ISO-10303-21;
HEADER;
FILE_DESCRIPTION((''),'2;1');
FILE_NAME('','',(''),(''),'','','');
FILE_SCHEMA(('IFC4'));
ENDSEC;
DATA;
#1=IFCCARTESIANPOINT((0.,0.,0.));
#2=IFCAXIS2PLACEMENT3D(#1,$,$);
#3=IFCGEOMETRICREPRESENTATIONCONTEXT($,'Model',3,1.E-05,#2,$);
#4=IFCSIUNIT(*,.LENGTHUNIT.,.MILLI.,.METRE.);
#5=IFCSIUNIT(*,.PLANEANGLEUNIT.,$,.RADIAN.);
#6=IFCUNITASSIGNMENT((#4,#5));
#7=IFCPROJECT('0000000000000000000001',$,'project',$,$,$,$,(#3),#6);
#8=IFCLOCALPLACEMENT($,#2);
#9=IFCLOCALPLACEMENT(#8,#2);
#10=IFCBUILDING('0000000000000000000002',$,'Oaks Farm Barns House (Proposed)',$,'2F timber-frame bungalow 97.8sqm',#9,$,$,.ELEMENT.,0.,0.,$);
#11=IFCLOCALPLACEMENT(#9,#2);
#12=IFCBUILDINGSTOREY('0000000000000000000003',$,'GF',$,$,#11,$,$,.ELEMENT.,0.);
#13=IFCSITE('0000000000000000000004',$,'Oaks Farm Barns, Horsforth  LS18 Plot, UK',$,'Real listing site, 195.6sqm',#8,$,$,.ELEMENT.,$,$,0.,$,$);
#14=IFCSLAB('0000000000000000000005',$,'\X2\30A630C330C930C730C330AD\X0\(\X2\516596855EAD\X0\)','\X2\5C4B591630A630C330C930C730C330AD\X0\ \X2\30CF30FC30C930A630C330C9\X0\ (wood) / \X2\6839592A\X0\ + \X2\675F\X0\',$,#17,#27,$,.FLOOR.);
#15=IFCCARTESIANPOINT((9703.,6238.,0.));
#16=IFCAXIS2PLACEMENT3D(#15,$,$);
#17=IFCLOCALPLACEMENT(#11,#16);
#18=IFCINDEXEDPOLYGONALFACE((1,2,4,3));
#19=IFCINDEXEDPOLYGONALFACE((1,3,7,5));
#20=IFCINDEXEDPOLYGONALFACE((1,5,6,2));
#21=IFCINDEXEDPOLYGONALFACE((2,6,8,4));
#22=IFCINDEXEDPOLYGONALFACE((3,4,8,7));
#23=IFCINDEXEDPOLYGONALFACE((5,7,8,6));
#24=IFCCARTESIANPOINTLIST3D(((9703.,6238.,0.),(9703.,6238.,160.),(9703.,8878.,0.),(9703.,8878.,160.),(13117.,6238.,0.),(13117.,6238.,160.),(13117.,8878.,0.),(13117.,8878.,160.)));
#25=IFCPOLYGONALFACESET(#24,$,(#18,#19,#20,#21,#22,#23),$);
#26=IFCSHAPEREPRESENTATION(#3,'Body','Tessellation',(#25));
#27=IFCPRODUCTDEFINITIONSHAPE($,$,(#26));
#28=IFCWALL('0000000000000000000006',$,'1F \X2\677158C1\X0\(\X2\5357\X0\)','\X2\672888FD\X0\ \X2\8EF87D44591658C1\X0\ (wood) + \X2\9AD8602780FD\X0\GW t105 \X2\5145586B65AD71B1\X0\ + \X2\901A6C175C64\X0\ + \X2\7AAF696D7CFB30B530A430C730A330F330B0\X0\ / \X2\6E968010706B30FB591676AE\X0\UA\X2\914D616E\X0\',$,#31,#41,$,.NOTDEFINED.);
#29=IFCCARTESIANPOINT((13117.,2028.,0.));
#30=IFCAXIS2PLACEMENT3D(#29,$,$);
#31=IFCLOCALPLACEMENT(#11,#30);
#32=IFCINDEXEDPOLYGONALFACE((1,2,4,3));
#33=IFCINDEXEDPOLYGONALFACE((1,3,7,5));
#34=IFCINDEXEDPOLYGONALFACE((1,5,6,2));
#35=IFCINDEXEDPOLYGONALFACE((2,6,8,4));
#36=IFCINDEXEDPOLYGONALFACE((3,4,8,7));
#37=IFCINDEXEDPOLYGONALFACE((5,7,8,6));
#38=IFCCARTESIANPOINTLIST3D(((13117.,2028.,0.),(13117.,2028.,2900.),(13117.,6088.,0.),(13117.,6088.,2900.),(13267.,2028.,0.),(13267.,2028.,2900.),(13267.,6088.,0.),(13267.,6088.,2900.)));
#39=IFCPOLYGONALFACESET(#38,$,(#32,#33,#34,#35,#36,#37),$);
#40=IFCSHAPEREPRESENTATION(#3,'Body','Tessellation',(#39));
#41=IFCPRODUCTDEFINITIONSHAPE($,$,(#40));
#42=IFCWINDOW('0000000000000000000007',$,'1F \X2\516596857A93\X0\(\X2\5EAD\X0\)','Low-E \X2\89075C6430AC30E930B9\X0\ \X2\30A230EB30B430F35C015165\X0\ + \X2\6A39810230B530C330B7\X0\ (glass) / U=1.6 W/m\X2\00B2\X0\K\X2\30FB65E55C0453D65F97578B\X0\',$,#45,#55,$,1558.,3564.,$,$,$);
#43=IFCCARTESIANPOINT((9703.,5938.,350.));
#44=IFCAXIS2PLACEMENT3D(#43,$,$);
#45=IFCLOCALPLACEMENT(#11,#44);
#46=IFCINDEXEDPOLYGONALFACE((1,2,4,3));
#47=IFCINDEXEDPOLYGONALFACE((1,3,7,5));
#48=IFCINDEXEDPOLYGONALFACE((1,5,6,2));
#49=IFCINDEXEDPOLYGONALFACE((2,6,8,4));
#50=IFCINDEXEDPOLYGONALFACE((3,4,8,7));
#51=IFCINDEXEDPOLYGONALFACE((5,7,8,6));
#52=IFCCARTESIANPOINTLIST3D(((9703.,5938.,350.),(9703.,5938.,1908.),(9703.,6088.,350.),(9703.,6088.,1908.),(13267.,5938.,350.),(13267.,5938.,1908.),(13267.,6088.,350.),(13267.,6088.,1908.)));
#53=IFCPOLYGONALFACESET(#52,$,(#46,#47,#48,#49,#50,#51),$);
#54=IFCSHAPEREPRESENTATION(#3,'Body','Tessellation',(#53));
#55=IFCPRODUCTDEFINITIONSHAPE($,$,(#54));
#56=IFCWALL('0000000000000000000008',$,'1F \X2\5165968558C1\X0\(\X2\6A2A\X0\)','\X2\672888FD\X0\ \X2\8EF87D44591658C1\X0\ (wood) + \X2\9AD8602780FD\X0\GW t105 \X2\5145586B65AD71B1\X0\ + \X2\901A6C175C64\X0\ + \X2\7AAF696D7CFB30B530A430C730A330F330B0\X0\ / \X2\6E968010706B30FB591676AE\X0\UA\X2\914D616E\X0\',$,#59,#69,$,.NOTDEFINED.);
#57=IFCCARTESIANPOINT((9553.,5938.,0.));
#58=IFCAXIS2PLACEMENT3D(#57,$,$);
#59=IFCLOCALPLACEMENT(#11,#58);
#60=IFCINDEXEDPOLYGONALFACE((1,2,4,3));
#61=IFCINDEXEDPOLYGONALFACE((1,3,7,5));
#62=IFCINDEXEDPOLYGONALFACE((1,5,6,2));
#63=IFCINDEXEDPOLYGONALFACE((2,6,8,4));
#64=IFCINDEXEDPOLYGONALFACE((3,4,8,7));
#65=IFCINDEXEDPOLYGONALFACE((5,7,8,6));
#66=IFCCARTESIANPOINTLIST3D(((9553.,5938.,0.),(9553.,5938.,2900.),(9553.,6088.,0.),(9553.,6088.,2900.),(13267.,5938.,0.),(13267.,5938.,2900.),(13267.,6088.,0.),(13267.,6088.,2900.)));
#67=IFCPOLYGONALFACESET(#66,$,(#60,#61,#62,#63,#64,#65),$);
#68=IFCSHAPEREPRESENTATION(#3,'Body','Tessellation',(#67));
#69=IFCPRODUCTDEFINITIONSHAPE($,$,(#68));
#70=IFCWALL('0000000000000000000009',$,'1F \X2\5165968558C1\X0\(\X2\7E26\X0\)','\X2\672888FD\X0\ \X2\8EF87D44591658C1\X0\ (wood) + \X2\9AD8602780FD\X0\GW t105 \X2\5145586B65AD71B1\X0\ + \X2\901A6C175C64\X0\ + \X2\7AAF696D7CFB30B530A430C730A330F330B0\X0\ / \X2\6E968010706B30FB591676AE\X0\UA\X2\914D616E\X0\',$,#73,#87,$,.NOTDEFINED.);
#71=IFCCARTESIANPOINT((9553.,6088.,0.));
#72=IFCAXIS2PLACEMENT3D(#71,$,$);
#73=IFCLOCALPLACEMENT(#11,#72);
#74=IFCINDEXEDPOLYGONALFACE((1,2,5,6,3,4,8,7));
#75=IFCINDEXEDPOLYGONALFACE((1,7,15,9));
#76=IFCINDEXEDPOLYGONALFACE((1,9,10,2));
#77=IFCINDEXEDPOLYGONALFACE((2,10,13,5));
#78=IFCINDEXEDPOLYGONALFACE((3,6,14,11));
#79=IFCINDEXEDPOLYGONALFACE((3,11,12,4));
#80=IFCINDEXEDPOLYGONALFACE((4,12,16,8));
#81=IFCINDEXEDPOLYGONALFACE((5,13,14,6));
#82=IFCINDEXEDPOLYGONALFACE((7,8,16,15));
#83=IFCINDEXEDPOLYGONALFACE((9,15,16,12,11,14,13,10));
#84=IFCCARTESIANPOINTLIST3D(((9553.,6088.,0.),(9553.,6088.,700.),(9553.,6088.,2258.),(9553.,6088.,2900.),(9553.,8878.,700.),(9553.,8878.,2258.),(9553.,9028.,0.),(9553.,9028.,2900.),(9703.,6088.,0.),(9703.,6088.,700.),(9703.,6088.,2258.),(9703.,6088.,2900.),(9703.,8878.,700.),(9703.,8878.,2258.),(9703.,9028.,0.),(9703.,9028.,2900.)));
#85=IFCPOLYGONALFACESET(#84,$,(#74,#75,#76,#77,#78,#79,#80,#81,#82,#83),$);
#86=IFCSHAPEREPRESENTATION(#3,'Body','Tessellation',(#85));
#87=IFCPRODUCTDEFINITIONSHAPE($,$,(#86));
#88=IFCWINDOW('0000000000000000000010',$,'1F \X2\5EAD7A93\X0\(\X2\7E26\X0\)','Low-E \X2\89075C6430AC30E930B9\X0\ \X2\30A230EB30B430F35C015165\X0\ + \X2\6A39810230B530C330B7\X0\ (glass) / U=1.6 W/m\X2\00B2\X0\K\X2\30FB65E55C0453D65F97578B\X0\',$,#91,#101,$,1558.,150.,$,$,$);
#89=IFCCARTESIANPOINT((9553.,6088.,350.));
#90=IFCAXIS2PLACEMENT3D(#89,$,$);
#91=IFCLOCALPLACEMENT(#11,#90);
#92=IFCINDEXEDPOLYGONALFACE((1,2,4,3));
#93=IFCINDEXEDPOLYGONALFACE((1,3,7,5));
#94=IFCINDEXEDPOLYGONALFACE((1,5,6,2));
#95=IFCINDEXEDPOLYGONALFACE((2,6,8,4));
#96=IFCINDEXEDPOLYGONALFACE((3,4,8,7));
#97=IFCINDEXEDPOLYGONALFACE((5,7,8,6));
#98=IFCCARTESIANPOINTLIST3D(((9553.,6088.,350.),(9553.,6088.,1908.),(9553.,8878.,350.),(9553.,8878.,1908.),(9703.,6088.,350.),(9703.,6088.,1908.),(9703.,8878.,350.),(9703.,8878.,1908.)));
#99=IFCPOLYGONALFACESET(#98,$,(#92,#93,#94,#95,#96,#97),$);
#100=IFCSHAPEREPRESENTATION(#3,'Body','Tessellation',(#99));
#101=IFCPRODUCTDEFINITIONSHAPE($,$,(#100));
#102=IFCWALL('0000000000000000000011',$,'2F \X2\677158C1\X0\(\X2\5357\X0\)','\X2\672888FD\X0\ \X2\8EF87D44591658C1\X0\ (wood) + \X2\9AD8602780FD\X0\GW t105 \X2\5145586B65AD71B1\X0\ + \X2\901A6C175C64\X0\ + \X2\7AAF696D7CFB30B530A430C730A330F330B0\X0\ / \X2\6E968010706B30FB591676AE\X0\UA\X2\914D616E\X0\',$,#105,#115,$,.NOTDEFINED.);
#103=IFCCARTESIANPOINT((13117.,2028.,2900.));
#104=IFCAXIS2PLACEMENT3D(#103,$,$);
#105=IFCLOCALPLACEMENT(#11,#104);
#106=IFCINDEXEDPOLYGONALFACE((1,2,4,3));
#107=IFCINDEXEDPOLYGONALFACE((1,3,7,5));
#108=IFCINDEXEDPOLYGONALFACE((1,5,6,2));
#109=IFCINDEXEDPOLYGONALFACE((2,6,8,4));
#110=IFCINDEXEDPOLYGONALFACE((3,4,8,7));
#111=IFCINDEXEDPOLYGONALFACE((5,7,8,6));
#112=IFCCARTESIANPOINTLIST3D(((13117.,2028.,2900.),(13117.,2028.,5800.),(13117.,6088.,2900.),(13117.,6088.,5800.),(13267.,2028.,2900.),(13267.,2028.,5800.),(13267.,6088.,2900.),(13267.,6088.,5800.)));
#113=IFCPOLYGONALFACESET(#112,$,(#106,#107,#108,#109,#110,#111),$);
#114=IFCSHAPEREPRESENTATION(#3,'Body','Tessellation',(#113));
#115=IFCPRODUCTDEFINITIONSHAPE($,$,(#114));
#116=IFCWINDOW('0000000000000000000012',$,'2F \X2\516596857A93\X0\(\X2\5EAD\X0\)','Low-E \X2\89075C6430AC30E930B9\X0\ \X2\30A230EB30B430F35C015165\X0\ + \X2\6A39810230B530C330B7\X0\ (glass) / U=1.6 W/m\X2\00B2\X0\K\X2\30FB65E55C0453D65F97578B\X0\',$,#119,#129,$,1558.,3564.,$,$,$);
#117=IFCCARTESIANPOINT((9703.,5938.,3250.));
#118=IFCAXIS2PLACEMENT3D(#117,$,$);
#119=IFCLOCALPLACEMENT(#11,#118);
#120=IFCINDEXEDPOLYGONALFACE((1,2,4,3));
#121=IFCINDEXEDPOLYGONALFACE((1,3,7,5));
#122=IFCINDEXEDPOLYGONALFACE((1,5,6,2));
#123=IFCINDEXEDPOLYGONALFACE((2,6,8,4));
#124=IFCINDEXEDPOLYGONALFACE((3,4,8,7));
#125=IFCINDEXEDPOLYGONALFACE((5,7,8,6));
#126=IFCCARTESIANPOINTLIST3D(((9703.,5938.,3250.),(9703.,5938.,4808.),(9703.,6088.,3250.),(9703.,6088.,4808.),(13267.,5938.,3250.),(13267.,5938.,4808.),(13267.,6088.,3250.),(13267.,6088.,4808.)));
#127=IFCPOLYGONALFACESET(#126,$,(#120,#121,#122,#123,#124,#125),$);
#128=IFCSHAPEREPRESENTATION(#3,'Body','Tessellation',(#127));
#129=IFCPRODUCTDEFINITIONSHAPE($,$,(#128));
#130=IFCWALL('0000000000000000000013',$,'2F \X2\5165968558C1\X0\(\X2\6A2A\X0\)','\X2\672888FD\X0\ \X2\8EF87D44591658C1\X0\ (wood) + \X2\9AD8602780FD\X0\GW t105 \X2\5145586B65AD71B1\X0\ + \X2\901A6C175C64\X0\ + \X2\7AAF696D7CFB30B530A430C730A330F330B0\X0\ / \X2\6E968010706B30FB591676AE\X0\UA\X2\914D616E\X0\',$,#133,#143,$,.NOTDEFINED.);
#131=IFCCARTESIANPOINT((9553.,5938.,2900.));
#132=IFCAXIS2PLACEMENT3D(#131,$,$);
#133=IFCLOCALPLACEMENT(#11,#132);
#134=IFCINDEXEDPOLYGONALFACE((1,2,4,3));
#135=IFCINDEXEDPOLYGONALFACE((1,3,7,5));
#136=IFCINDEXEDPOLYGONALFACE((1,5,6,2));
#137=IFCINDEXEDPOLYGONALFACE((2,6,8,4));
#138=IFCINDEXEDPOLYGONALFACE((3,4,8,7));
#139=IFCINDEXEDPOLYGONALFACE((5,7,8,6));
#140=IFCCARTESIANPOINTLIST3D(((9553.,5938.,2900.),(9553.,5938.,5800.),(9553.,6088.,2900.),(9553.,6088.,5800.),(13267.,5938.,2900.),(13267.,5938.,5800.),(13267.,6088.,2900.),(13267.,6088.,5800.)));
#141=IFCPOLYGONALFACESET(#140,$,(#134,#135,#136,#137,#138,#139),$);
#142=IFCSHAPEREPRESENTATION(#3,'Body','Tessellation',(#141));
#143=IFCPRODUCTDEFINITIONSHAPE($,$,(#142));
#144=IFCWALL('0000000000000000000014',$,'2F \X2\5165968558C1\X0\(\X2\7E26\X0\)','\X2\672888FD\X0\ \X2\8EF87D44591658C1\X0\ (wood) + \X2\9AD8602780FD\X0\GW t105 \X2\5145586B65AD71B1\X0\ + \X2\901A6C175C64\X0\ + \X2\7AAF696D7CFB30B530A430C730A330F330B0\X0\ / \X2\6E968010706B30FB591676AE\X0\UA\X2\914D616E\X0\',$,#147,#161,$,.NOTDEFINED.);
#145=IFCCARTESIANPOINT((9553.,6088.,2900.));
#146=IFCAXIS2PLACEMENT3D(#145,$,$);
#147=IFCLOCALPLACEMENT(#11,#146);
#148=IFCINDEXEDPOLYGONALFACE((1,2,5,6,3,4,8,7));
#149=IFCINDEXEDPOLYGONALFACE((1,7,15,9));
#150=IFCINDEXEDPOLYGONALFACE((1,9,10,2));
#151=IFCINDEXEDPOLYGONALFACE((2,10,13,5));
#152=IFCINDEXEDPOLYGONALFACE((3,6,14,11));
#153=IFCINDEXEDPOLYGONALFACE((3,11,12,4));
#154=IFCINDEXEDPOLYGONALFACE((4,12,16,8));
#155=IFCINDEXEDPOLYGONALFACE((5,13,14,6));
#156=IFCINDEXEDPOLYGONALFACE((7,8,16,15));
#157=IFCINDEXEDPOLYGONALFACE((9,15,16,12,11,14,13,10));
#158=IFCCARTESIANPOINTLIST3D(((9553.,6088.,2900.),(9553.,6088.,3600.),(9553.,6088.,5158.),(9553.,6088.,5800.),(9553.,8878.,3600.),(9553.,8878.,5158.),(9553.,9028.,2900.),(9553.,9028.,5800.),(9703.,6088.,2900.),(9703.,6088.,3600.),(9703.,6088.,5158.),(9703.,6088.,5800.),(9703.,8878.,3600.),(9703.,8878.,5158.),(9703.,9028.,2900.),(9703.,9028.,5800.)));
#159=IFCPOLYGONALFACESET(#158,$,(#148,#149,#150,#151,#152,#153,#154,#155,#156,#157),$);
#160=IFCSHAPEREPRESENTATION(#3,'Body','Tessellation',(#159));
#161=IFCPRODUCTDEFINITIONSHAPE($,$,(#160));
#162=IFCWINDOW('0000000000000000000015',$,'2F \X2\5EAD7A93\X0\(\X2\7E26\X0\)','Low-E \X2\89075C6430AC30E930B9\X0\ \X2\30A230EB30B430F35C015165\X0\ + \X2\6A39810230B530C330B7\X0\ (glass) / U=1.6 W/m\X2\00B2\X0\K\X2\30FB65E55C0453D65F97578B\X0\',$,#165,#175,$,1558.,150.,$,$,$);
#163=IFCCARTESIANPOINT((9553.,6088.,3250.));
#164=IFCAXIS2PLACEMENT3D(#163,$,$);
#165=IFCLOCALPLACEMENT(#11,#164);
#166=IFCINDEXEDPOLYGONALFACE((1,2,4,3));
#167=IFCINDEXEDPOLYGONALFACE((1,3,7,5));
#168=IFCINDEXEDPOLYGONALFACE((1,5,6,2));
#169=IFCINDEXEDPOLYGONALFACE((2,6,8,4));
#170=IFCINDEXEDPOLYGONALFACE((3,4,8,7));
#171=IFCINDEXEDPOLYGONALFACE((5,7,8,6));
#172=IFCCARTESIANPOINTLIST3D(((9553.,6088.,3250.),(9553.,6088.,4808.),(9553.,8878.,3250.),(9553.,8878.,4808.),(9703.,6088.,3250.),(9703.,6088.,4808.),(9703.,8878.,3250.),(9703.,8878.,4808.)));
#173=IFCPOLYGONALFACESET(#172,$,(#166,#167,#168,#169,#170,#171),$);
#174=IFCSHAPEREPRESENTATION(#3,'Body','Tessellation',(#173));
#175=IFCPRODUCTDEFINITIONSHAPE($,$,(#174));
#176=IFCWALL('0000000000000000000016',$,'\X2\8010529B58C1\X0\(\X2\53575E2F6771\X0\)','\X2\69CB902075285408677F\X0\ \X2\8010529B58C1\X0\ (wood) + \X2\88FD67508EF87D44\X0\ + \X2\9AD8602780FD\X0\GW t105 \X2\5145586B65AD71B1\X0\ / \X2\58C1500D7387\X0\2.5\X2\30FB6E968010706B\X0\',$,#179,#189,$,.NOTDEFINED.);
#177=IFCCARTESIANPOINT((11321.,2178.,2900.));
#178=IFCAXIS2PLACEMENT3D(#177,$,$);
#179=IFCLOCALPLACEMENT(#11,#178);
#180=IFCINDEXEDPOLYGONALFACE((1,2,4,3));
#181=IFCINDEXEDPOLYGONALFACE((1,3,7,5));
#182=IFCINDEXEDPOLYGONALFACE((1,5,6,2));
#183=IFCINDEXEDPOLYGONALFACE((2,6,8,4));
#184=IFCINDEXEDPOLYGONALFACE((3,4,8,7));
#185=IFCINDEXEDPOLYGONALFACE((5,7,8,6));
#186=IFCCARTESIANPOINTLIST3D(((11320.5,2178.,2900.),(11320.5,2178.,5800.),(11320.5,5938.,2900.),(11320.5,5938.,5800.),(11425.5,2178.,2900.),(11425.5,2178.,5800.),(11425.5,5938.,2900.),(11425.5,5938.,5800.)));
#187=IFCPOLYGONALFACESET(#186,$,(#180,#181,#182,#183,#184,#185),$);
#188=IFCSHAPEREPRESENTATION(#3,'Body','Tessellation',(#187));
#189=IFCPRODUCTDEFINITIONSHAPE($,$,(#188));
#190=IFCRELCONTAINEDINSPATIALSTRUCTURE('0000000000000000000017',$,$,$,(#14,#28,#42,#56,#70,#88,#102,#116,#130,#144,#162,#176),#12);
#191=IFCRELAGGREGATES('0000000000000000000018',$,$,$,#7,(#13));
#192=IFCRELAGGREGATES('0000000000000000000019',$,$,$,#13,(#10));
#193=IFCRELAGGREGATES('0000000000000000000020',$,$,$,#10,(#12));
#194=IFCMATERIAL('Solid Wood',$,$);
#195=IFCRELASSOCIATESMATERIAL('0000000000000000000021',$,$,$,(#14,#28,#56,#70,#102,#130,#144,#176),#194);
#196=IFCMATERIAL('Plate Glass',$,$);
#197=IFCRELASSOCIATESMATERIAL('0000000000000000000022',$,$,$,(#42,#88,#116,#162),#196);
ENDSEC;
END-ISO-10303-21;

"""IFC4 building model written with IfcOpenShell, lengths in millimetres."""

from ifc_helpers import new_model, si_unit, frame, frame_2d, origin, place, context, project, spatial, rectangle, extrude, material, element, fill, save


model = new_model("IFC4")

# Units and contexts
model_context = context("Model", 3, precision=1e-05, world=origin())
ifc_project = project(units=[si_unit("LENGTHUNIT", "METRE", prefix="MILLI"), si_unit("PLANEANGLEUNIT", "RADIAN")], contexts=[model_context])

# Site, building, storey
site_placement = place(None, origin())
site = spatial("IfcSite", under=ifc_project, at=site_placement, Name="Oaks Farm Barns, Horsforth  LS18 Plot, UK", ObjectType="Real listing site, 195.6sqm", CompositionType="ELEMENT", RefElevation=0.0)
building_placement = place(site_placement, origin())
building = spatial("IfcBuilding", under=site, at=building_placement, Name="Oaks Farm Barns House (Proposed)", ObjectType="2F timber-frame bungalow 97.8sqm", CompositionType="ELEMENT", ElevationOfRefHeight=0.0, ElevationOfTerrain=0.0)
storey_placement = place(building_placement, origin())
storey = spatial("IfcBuildingStorey", under=building, at=storey_placement, Name="GF", CompositionType="ELEMENT", Elevation=0.0)

# Slab
ifc_material_1 = material(Name="Solid Wood")
slab_placement = place(storey_placement, frame((9703.0, 6238.0, 0.0)))
element("IfcSlab", 1, at=slab_placement, inside=storey, material=ifc_material_1, Name="ウッドデッキ(入隅庭)", Description="屋外ウッドデッキ ハードウッド (wood) / 根太 + 束", PredefinedType="FLOOR", context=model_context, shape_type="SweptSolid", body=[
    extrude(rectangle(XDim=3414.0, YDim=2640.0, at=frame_2d((1707.0, 1320.0))), frame((9703.0, 6238.0, 0.0)), (0.0, 0.0, 1.0), 160.0),
])

# Wall, opening, window
wall_1_placement = place(storey_placement, frame((13117.0, 2028.0, 0.0)))
wall_1 = element("IfcWall", 2, at=wall_1_placement, inside=storey, material=ifc_material_1, Name="1F 東壁(南)", Description="木製 軸組外壁 (wood) + 高性能GW t105 充填断熱 + 通気層 + 窯業系サイディング / 準耐火・外皮UA配慮", PredefinedType="NOTDEFINED", context=model_context, shape_type="SweptSolid", body=[
    extrude(rectangle(XDim=150.0, YDim=4060.0, at=frame_2d((75.0, 2030.0))), frame((13117.0, 2028.0, 0.0)), (0.0, 0.0, 1.0), 2900.0),
])
opening_1_placement = place(storey_placement, frame((9703.0, 5938.0, 350.0)))
opening_1 = element("IfcOpeningElement", 3, at=opening_1_placement, cuts=wall_1, PredefinedType="NOTDEFINED", context=model_context, shape_type="SweptSolid", body=[
    extrude(rectangle(XDim=3564.0, YDim=150.0, at=frame_2d((1782.0, 75.0))), frame((9703.0, 5938.0, 350.0)), (0.0, 0.0, 1.0), 1558.0),
])
ifc_material_2 = material(Name="Plate Glass")
window_1_placement = place(storey_placement, frame((9703.0, 5938.0, 350.0)))
window_1 = element("IfcWindow", 4, at=window_1_placement, inside=storey, material=ifc_material_2, Name="1F 入隅窓(庭)", Description="Low-E 複層ガラス アルゴン封入 + 樹脂サッシ (glass) / U=1.6 W/m²K・日射取得型", OverallHeight=1558.0, OverallWidth=3564.0, context=model_context, shape_type="SweptSolid", body=[
    extrude(rectangle(XDim=3564.0, YDim=150.0, at=frame_2d((1782.0, 75.0))), frame((9703.0, 5938.0, 350.0)), (0.0, 0.0, 1.0), 1558.0),
])
fill(opening_1, window_1)

# Wall
wall_2_placement = place(storey_placement, frame((9553.0, 5938.0, 0.0)))
element("IfcWall", 5, at=wall_2_placement, inside=storey, material=ifc_material_1, Name="1F 入隅壁(横)", Description="木製 軸組外壁 (wood) + 高性能GW t105 充填断熱 + 通気層 + 窯業系サイディング / 準耐火・外皮UA配慮", PredefinedType="NOTDEFINED", context=model_context, shape_type="SweptSolid", body=[
    extrude(rectangle(XDim=3714.0, YDim=150.0, at=frame_2d((1857.0, 75.0))), frame((9553.0, 5938.0, 0.0)), (0.0, 0.0, 1.0), 2900.0),
])

# Wall, opening, window
wall_3_placement = place(storey_placement, frame((9553.0, 6088.0, 0.0)))
wall_3 = element("IfcWall", 6, at=wall_3_placement, inside=storey, material=ifc_material_1, Name="1F 入隅壁(縦)", Description="木製 軸組外壁 (wood) + 高性能GW t105 充填断熱 + 通気層 + 窯業系サイディング / 準耐火・外皮UA配慮", PredefinedType="NOTDEFINED", context=model_context, shape_type="SweptSolid", body=[
    extrude(rectangle(XDim=150.0, YDim=2940.0, at=frame_2d((75.0, 1470.0))), frame((9553.0, 6088.0, 0.0)), (0.0, 0.0, 1.0), 2900.0),
])
opening_2_placement = place(storey_placement, frame((9553.0, 6088.0, 350.0)))
opening_2 = element("IfcOpeningElement", 7, at=opening_2_placement, cuts=wall_3, PredefinedType="NOTDEFINED", context=model_context, shape_type="SweptSolid", body=[
    extrude(rectangle(XDim=150.0, YDim=2790.0, at=frame_2d((75.0, 1395.0))), frame((9553.0, 6088.0, 350.0)), (0.0, 0.0, 1.0), 1558.0),
])
window_2_placement = place(storey_placement, frame((9553.0, 6088.0, 350.0)))
window_2 = element("IfcWindow", 8, at=window_2_placement, inside=storey, material=ifc_material_2, Name="1F 庭窓(縦)", Description="Low-E 複層ガラス アルゴン封入 + 樹脂サッシ (glass) / U=1.6 W/m²K・日射取得型", OverallHeight=1558.0, OverallWidth=150.0, context=model_context, shape_type="SweptSolid", body=[
    extrude(rectangle(XDim=150.0, YDim=2790.0, at=frame_2d((75.0, 1395.0))), frame((9553.0, 6088.0, 350.0)), (0.0, 0.0, 1.0), 1558.0),
])
fill(opening_2, window_2)

# Wall, opening, window
wall_4_placement = place(storey_placement, frame((13117.0, 2028.0, 2900.0)))
wall_4 = element("IfcWall", 9, at=wall_4_placement, inside=storey, material=ifc_material_1, Name="2F 東壁(南)", Description="木製 軸組外壁 (wood) + 高性能GW t105 充填断熱 + 通気層 + 窯業系サイディング / 準耐火・外皮UA配慮", PredefinedType="NOTDEFINED", context=model_context, shape_type="SweptSolid", body=[
    extrude(rectangle(XDim=150.0, YDim=4060.0, at=frame_2d((75.0, 2030.0))), frame((13117.0, 2028.0, 2900.0)), (0.0, 0.0, 1.0), 2900.0),
])
opening_3_placement = place(storey_placement, frame((9703.0, 5938.0, 3250.0)))
opening_3 = element("IfcOpeningElement", 10, at=opening_3_placement, cuts=wall_4, PredefinedType="NOTDEFINED", context=model_context, shape_type="SweptSolid", body=[
    extrude(rectangle(XDim=3564.0, YDim=150.0, at=frame_2d((1782.0, 75.0))), frame((9703.0, 5938.0, 3250.0)), (0.0, 0.0, 1.0), 1558.0),
])
window_3_placement = place(storey_placement, frame((9703.0, 5938.0, 3250.0)))
window_3 = element("IfcWindow", 11, at=window_3_placement, inside=storey, material=ifc_material_2, Name="2F 入隅窓(庭)", Description="Low-E 複層ガラス アルゴン封入 + 樹脂サッシ (glass) / U=1.6 W/m²K・日射取得型", OverallHeight=1558.0, OverallWidth=3564.0, context=model_context, shape_type="SweptSolid", body=[
    extrude(rectangle(XDim=3564.0, YDim=150.0, at=frame_2d((1782.0, 75.0))), frame((9703.0, 5938.0, 3250.0)), (0.0, 0.0, 1.0), 1558.0),
])
fill(opening_3, window_3)

# Wall
wall_5_placement = place(storey_placement, frame((9553.0, 5938.0, 2900.0)))
element("IfcWall", 12, at=wall_5_placement, inside=storey, material=ifc_material_1, Name="2F 入隅壁(横)", Description="木製 軸組外壁 (wood) + 高性能GW t105 充填断熱 + 通気層 + 窯業系サイディング / 準耐火・外皮UA配慮", PredefinedType="NOTDEFINED", context=model_context, shape_type="SweptSolid", body=[
    extrude(rectangle(XDim=3714.0, YDim=150.0, at=frame_2d((1857.0, 75.0))), frame((9553.0, 5938.0, 2900.0)), (0.0, 0.0, 1.0), 2900.0),
])

# Wall, opening, window
wall_6_placement = place(storey_placement, frame((9553.0, 6088.0, 2900.0)))
wall_6 = element("IfcWall", 13, at=wall_6_placement, inside=storey, material=ifc_material_1, Name="2F 入隅壁(縦)", Description="木製 軸組外壁 (wood) + 高性能GW t105 充填断熱 + 通気層 + 窯業系サイディング / 準耐火・外皮UA配慮", PredefinedType="NOTDEFINED", context=model_context, shape_type="SweptSolid", body=[
    extrude(rectangle(XDim=150.0, YDim=2940.0, at=frame_2d((75.0, 1470.0))), frame((9553.0, 6088.0, 2900.0)), (0.0, 0.0, 1.0), 2900.0),
])
opening_4_placement = place(storey_placement, frame((9553.0, 6088.0, 3250.0)))
opening_4 = element("IfcOpeningElement", 14, at=opening_4_placement, cuts=wall_6, PredefinedType="NOTDEFINED", context=model_context, shape_type="SweptSolid", body=[
    extrude(rectangle(XDim=150.0, YDim=2790.0, at=frame_2d((75.0, 1395.0))), frame((9553.0, 6088.0, 3250.0)), (0.0, 0.0, 1.0), 1558.0),
])
window_4_placement = place(storey_placement, frame((9553.0, 6088.0, 3250.0)))
window_4 = element("IfcWindow", 15, at=window_4_placement, inside=storey, material=ifc_material_2, Name="2F 庭窓(縦)", Description="Low-E 複層ガラス アルゴン封入 + 樹脂サッシ (glass) / U=1.6 W/m²K・日射取得型", OverallHeight=1558.0, OverallWidth=150.0, context=model_context, shape_type="SweptSolid", body=[
    extrude(rectangle(XDim=150.0, YDim=2790.0, at=frame_2d((75.0, 1395.0))), frame((9553.0, 6088.0, 3250.0)), (0.0, 0.0, 1.0), 1558.0),
])
fill(opening_4, window_4)

# Wall
wall_7_placement = place(storey_placement, frame((11321.0, 2178.0, 2900.0)))
element("IfcWall", 16, at=wall_7_placement, inside=storey, material=ifc_material_1, Name="耐力壁(南帯東)", Description="構造用合板 耐力壁 (wood) + 製材軸組 + 高性能GW t105 充填断熱 / 壁倍率2.5・準耐火", PredefinedType="NOTDEFINED", context=model_context, shape_type="SweptSolid", body=[
    extrude(rectangle(XDim=105.0, YDim=3760.0, at=frame_2d((52.0, 1880.0))), frame((11321.0, 2178.0, 2900.0)), (0.0, 0.0, 1.0), 2900.0),
])

save(model, "model.ifc")
